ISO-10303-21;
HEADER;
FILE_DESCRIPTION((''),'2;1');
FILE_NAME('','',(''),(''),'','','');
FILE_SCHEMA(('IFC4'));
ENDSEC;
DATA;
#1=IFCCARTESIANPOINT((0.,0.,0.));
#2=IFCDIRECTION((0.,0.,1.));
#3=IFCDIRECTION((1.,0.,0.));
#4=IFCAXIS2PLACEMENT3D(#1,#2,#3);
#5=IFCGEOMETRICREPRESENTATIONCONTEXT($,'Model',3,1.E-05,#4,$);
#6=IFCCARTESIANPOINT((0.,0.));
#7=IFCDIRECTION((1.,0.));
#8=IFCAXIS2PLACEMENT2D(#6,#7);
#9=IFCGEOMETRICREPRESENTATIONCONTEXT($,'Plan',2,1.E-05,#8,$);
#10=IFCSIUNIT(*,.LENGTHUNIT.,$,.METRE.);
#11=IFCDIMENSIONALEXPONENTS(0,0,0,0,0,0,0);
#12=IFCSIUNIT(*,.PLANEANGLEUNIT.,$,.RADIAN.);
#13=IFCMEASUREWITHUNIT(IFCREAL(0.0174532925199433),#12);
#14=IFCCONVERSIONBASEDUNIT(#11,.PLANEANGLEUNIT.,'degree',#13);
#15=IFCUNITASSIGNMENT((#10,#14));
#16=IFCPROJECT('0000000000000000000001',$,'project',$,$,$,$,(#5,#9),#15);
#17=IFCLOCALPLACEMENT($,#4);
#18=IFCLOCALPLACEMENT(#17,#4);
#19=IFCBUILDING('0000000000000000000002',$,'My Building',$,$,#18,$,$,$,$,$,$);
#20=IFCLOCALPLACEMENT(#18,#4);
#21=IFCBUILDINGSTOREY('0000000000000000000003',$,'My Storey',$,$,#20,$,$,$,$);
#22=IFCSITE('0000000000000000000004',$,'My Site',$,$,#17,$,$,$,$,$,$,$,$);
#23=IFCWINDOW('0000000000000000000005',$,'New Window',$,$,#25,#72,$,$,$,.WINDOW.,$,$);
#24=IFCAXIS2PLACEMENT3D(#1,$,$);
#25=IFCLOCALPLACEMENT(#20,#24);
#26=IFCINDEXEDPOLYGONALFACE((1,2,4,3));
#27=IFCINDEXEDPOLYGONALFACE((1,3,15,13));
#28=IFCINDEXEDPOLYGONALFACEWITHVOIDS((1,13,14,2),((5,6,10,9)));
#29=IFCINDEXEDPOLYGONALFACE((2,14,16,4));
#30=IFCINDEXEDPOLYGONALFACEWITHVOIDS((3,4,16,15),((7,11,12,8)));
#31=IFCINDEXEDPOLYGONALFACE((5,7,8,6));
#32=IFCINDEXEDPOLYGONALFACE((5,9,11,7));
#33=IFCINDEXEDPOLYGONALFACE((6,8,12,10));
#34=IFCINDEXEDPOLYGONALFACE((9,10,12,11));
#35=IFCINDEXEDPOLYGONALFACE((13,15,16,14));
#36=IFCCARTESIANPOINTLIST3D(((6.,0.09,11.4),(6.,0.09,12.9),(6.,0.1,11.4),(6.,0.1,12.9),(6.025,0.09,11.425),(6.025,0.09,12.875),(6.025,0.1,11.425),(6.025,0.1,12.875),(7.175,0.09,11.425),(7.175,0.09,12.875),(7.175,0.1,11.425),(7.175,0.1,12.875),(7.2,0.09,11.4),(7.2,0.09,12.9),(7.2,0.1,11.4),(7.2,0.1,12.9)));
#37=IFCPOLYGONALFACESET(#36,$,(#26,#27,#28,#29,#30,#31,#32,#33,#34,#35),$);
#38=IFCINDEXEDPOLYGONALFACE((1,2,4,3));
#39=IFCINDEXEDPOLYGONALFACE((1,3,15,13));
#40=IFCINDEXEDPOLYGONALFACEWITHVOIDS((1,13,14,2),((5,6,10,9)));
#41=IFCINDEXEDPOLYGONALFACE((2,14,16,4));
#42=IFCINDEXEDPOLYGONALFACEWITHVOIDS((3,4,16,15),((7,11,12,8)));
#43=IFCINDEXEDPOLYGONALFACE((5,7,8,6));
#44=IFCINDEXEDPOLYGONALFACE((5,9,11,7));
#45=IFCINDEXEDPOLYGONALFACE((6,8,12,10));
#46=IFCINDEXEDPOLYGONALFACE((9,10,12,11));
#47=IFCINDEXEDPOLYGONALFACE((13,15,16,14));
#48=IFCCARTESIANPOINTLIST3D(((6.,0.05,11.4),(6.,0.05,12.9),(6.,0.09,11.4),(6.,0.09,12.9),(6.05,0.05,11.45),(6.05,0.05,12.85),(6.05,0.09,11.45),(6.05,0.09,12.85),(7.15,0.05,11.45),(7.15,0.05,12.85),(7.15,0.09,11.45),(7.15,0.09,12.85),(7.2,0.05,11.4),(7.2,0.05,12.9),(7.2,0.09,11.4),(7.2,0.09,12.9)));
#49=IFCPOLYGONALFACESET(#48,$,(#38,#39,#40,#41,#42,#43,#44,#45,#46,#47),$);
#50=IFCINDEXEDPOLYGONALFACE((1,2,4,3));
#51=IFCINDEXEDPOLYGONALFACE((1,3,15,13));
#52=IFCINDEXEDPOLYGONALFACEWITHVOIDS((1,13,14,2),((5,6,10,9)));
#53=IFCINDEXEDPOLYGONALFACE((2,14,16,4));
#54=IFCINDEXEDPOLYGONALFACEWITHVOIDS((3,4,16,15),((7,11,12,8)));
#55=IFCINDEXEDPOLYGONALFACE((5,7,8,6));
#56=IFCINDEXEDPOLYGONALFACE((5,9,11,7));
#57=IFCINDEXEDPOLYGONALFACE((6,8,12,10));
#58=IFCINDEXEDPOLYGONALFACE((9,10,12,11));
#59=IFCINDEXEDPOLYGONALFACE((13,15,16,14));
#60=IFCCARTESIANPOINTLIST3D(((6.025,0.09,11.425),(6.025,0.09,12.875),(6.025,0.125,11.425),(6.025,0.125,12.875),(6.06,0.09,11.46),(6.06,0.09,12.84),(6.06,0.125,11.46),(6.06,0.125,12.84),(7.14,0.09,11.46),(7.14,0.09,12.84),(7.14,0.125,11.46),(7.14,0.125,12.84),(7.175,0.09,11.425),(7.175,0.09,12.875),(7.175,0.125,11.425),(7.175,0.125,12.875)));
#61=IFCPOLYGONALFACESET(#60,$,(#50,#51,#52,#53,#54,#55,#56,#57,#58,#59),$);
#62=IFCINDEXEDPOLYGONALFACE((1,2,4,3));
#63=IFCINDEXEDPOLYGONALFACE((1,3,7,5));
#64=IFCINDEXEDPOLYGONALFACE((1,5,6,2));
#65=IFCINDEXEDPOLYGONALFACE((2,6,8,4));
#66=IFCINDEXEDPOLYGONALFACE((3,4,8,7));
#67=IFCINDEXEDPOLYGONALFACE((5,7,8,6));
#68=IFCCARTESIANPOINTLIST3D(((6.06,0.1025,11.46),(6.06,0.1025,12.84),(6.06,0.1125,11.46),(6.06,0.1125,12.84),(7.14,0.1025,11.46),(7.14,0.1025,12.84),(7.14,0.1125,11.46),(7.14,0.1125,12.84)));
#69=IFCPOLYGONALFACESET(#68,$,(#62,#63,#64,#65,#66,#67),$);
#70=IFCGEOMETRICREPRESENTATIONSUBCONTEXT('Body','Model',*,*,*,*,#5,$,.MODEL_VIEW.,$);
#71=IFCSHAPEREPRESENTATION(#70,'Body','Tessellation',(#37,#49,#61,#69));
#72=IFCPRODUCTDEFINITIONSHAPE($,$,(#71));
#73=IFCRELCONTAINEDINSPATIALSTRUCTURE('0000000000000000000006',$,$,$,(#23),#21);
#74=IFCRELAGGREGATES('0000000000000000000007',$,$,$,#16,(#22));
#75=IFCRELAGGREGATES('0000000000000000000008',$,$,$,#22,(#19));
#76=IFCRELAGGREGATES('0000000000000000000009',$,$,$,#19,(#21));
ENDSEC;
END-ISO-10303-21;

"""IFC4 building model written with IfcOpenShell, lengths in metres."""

from ifc_helpers import new_model, entity, si_unit, converted_unit, frame, origin_with_axes, origin_2d_with_axis, place, context, subcontext, project, spatial, line, indexed_curve, outline, extrude, element, save


model = new_model("IFC4")

# Units and contexts
model_context = context("Model", 3, precision=1e-05, world=origin_with_axes())
plan_context = context("Plan", 2, precision=1e-05, world=origin_2d_with_axis())
body_context = subcontext(model_context, "Body", "Model", "MODEL_VIEW")
ifc_project = project(units=[si_unit("LENGTHUNIT", "METRE"), converted_unit("PLANEANGLEUNIT", "degree", entity("IfcReal", 0.0174532925199433), si_unit("PLANEANGLEUNIT", "RADIAN"), dimensions=[0, 0, 0, 0, 0, 0, 0])], contexts=[model_context, plan_context])

# Site, building, storey
site_placement = place(None, origin_with_axes())
site = spatial("IfcSite", under=ifc_project, at=site_placement, Name="My Site")
building_placement = place(site_placement, origin_with_axes())
building = spatial("IfcBuilding", under=site, at=building_placement, Name="My Building")
storey_placement = place(building_placement, origin_with_axes())
storey = spatial("IfcBuildingStorey", under=building, at=storey_placement, Name="My Storey")

# Window
window_placement = place(storey_placement, frame((6.0, 0.0, 11.4), z_axis=(0.0, 0.0, 1.0), x_axis=(1.0, 0.0, 0.0)))
element("IfcWindow", 1, at=window_placement, inside=storey, Name="New Window", PredefinedType="WINDOW", context=body_context, shape_type="SweptSolid", body=[
    extrude(outline(indexed_curve([(0.0, 0.0), (1.2, 0.0), (1.2, 1.5), (0.0, 1.5)], segments=[line(1, 2, 3, 4, 1)]), holes=[indexed_curve([(0.025, 0.025), (1.175, 0.025), (1.175, 1.475), (0.025, 1.475)], segments=[line(1, 2, 3, 4, 1)])]), frame((0.0, 0.09, 0.0), z_axis=(0.0, -1.0, 0.0), x_axis=(1.0, 0.0, 0.0)), (0.0, 0.0, -1.0), 0.01),
    extrude(outline(indexed_curve([(0.0, 0.0), (1.2, 0.0), (1.2, 1.5), (0.0, 1.5)], segments=[line(1, 2, 3, 4, 1)]), holes=[indexed_curve([(0.05, 0.05), (1.15, 0.05), (1.15, 1.45), (0.05, 1.45)], segments=[line(1, 2, 3, 4, 1)])]), frame((0.0, 0.05, 0.0), z_axis=(0.0, -1.0, 0.0), x_axis=(1.0, 0.0, 0.0)), (0.0, 0.0, -1.0), 0.04),
    extrude(outline(indexed_curve([(0.0, 0.0), (1.15, 0.0), (1.15, 1.45), (0.0, 1.45)], segments=[line(1, 2, 3, 4, 1)]), holes=[indexed_curve([(0.035, 0.035), (1.115, 0.035), (1.115, 1.415), (0.035, 1.415)], segments=[line(1, 2, 3, 4, 1)])]), frame((0.025, 0.09, 0.025), z_axis=(0.0, -1.0, 0.0), x_axis=(1.0, 0.0, 0.0)), (0.0, 0.0, -1.0), 0.035),
    extrude(outline(indexed_curve([(0.035, 0.035), (1.115, 0.035), (1.115, 1.415), (0.035, 1.415)], segments=[line(1, 2, 3, 4, 1)])), frame((0.025, 0.1025, 0.025), z_axis=(0.0, -1.0, 0.0), x_axis=(1.0, 0.0, 0.0)), (0.0, 0.0, -1.0), 0.01),
])

save(model, "model.ifc")
